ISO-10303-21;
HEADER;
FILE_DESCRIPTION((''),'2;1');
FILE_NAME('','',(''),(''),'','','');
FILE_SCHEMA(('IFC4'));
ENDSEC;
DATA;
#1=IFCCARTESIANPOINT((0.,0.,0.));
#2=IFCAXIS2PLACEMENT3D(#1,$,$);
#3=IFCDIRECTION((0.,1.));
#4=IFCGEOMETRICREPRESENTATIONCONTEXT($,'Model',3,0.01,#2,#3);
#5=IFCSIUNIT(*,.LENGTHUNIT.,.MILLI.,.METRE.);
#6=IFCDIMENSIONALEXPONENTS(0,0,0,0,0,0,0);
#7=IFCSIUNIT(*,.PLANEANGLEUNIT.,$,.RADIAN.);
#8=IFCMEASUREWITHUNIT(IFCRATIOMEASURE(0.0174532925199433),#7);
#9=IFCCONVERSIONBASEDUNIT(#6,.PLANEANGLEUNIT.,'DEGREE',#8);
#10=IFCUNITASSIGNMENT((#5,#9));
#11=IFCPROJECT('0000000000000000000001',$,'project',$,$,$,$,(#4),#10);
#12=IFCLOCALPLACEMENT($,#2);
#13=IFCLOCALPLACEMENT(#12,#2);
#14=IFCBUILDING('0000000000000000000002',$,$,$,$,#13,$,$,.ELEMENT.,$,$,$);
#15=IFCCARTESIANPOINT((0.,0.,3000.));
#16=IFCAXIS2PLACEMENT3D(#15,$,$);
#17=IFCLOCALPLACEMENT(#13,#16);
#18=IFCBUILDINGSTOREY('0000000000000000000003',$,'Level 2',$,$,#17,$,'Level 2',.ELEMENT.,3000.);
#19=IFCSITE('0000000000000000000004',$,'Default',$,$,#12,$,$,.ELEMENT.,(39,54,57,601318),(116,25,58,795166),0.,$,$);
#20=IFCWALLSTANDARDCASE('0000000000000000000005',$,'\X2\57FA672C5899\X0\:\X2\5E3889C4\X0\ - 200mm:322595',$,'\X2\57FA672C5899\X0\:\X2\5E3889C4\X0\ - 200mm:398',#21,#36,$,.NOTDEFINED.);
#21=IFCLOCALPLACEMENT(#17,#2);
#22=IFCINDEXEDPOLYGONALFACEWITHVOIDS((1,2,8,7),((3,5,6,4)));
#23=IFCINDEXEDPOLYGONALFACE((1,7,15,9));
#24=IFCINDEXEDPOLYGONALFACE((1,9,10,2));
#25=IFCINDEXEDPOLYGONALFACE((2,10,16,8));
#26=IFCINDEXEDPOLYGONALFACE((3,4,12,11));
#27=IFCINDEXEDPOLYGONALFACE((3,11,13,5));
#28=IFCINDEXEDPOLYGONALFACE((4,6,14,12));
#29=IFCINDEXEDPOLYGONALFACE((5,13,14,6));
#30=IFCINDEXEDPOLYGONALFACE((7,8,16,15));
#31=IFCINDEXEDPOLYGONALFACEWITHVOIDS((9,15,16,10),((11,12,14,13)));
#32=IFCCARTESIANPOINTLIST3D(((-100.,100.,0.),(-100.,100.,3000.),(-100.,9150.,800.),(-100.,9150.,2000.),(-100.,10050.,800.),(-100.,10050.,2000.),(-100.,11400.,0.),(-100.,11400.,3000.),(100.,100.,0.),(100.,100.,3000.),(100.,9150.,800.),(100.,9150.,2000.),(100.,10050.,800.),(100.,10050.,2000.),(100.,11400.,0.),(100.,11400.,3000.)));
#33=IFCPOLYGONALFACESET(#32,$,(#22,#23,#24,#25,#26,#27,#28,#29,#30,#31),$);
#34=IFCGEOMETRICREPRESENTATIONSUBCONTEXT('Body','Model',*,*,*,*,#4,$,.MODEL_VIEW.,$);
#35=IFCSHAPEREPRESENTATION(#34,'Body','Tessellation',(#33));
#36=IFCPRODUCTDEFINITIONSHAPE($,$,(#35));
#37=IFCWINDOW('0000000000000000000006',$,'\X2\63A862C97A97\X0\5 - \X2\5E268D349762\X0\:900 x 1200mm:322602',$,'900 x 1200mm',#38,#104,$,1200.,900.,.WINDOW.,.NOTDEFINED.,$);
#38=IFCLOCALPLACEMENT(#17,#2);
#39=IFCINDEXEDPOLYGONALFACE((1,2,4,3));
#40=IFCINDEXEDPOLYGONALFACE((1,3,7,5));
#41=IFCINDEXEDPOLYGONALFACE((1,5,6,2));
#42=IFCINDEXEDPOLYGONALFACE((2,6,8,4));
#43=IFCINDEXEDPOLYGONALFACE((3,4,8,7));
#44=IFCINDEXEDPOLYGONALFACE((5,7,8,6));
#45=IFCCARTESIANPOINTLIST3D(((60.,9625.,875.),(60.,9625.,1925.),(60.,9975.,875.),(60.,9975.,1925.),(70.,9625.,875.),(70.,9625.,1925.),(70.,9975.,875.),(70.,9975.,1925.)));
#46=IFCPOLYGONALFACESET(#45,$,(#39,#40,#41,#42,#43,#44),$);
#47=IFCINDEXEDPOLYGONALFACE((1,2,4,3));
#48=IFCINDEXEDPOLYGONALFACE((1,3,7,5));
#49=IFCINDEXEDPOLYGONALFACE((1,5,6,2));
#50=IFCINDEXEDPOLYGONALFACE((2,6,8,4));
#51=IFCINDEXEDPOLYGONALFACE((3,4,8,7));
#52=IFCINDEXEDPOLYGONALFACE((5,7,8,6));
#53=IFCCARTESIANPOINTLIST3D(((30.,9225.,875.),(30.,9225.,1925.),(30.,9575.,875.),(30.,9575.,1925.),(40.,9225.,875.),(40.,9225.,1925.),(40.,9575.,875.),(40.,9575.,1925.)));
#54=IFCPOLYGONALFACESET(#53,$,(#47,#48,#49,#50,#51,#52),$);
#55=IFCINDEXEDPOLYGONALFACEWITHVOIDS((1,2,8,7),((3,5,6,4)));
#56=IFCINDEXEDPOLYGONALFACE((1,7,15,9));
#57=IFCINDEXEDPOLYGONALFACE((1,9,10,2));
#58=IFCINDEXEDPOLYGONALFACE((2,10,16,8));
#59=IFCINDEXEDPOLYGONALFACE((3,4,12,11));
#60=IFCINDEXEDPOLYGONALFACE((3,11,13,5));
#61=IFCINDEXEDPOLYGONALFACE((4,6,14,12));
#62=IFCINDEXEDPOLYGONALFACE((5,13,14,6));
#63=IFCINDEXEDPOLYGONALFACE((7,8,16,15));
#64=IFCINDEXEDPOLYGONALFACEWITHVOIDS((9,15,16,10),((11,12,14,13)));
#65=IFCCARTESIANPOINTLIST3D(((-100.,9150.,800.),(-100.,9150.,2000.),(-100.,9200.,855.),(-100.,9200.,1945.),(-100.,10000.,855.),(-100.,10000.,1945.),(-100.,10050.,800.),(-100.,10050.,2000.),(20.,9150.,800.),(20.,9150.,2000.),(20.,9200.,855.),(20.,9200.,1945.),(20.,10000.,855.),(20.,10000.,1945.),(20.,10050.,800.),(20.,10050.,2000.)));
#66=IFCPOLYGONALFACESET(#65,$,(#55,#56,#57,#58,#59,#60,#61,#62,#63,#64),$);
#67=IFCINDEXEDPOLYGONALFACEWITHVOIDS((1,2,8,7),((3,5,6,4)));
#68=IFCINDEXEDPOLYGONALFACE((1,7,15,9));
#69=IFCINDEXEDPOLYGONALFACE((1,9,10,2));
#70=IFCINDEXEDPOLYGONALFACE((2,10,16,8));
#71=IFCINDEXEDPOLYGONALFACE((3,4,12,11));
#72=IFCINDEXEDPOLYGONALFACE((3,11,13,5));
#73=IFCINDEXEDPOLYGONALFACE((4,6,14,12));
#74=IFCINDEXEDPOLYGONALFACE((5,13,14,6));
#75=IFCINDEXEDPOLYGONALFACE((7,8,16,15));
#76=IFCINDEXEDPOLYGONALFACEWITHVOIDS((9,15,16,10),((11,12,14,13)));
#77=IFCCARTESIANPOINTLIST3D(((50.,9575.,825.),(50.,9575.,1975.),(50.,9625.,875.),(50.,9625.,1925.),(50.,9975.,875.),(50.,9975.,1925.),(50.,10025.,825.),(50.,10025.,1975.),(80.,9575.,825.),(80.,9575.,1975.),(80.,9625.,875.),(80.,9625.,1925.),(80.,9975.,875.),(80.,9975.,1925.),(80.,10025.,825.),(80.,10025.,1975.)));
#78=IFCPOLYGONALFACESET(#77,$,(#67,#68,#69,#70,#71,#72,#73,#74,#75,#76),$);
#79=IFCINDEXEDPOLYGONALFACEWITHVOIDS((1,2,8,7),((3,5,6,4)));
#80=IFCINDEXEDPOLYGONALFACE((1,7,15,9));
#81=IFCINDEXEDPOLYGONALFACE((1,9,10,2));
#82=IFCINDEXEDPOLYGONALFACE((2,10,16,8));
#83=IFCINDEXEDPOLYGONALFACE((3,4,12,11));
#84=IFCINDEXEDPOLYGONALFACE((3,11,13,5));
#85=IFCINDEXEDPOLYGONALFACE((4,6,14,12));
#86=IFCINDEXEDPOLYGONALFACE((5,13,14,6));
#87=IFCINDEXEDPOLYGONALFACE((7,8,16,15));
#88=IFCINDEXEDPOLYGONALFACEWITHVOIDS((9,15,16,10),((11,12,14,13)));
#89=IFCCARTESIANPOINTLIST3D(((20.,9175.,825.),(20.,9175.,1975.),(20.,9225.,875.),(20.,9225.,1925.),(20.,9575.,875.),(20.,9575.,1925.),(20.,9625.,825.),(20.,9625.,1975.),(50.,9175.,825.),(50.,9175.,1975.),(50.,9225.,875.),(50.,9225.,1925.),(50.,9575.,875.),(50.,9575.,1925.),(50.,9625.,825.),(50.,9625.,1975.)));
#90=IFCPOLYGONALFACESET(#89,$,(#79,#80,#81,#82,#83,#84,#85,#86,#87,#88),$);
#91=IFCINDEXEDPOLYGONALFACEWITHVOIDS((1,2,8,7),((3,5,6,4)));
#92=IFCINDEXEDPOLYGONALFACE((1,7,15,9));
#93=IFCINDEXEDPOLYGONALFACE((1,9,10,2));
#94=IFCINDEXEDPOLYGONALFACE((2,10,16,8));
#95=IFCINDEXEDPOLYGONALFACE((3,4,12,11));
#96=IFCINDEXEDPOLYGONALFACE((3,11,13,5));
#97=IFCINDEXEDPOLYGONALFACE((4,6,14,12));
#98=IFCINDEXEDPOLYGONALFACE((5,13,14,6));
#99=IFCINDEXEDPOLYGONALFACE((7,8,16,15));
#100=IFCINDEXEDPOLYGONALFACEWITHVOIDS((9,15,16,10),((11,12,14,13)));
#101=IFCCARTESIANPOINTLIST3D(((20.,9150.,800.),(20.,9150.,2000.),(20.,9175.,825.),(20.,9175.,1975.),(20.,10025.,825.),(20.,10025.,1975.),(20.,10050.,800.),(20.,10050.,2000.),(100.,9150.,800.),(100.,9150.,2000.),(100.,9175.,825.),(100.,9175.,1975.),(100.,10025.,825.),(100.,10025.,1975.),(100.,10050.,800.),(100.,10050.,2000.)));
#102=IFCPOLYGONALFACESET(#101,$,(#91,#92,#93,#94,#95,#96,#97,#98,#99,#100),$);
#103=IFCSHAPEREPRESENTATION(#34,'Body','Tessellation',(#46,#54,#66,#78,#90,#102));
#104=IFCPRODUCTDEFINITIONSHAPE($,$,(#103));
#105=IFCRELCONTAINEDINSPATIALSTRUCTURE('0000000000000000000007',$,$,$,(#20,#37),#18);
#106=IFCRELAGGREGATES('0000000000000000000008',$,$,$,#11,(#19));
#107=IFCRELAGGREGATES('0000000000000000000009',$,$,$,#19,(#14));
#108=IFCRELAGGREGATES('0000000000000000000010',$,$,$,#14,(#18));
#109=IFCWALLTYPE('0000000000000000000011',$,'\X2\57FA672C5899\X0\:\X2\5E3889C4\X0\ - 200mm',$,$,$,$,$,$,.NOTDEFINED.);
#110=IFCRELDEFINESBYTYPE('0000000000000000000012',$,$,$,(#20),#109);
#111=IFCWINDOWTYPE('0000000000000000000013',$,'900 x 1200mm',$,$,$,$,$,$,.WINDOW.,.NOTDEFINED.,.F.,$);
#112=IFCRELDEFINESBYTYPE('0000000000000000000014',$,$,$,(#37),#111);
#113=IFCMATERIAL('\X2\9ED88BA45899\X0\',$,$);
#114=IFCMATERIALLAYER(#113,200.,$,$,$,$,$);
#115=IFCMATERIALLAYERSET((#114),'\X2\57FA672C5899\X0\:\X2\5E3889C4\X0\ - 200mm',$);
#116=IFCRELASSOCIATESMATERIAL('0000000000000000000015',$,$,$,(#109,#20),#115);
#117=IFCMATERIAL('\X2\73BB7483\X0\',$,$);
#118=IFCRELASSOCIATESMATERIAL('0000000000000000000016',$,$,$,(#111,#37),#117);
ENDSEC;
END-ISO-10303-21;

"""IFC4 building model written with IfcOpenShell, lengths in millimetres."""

from ifc_helpers import new_model, entity, si_unit, converted_unit, direction, frame, frame_2d, origin, origin_2d_with_axis, place, context, subcontext, project, spatial, polyline, rectangle, outline, extrude, source, transform, mapped, material, layer, layer_set, layer_usage, type_object, type_shapes, element, fill, save


model = new_model("IFC4")

# Units and contexts
model_context_1 = context("Model", 3, precision=0.01, world=origin(), true_north=direction((0.0, 1.0)))
body_context_1 = subcontext(model_context_1, "Body", "Model", "MODEL_VIEW")
ifc_project = project(units=[si_unit("LENGTHUNIT", "METRE", prefix="MILLI"), converted_unit("PLANEANGLEUNIT", "DEGREE", entity("IfcRatioMeasure", 0.0174532925199433), si_unit("PLANEANGLEUNIT", "RADIAN"), dimensions=[0, 0, 0, 0, 0, 0, 0])], contexts=[model_context_1])

# Site, building, storey
site_placement = place(None, origin())
site = spatial("IfcSite", under=ifc_project, at=site_placement, Name="Default", CompositionType="ELEMENT", RefLatitude=(39, 54, 57, 601318), RefLongitude=(116, 25, 58, 795166), RefElevation=0.0)
building_placement = place(site_placement, origin())
building = spatial("IfcBuilding", under=site, at=building_placement, CompositionType="ELEMENT")
storey_placement = place(building_placement, frame((0.0, 0.0, 3000.0)))
storey = spatial("IfcBuildingStorey", under=building, at=storey_placement, Name="Level 2", LongName="Level 2", CompositionType="ELEMENT", Elevation=3000.0)

# Shared definitions
ifc_material_1 = material(Name="默认墙")
ifc_layer_1 = layer(ifc_material_1, 200.0)
ifc_layer_set_1 = layer_set([ifc_layer_1], Name="基本墙:常规 - 200mm")
wall_type = type_object("IfcWallType", Name="基本墙:常规 - 200mm", PredefinedType="NOTDEFINED", material=ifc_layer_set_1)

# Wall, opening, window
ifc_material_2 = material(Name="玻璃")
window_type = type_object("IfcWindowType", Name="900 x 1200mm", ParameterTakesPrecedence=False, PartitioningType="NOTDEFINED", PredefinedType="WINDOW", material=ifc_material_2)
shared_shape_1 = source(origin(), body_context_1, "Body", "SweptSolid", [
    extrude(rectangle(XDim=10.0, YDim=350.0, at=origin_2d_with_axis()), frame((250.0, 165.0, 75.0), z_axis=(0.0, 0.0, 1.0), x_axis=(0.0, -1.0, 0.0)), (0.0, 0.0, 1.0), 1050.0),
    extrude(rectangle(XDim=10.0, YDim=350.0, at=frame_2d((0.0, 0.0), x_axis=(1.0, 0.0))), frame((650.0, 135.0, 75.0), z_axis=(0.0, 0.0, 1.0), x_axis=(0.0, -1.0, 0.0)), (0.0, 0.0, 1.0), 1050.0),
    extrude(outline(polyline([(-450.0, -600.0), (450.0, -600.0), (450.0, 600.0), (-450.0, 600.0), (-450.0, -600.0)]), holes=[polyline([(400.0, -545.0), (-400.0, -545.0), (-400.0, 545.0), (400.0, 545.0), (400.0, -545.0)])]), frame((450.0, 0.0, 600.0), z_axis=(0.0, 1.0, 0.0), x_axis=(1.0, 0.0, 0.0)), (0.0, 0.0, 1.0), 120.0),
    extrude(outline(polyline([(-225.0, -575.0), (225.0, -575.0), (225.0, 575.0), (-225.0, 575.0), (-225.0, -575.0)]), holes=[polyline([(-175.0, -525.0), (-175.0, 525.0), (175.0, 525.0), (175.0, -525.0), (-175.0, -525.0)])]), frame((250.0, 150.0, 600.0), z_axis=(0.0, 1.0, 0.0), x_axis=(-1.0, 0.0, 0.0)), (0.0, 0.0, 1.0), 30.0),
    extrude(outline(polyline([(-225.0, -575.0), (225.0, -575.0), (225.0, 575.0), (-225.0, 575.0), (-225.0, -575.0)]), holes=[polyline([(-175.0, -525.0), (-175.0, 525.0), (175.0, 525.0), (175.0, -525.0), (-175.0, -525.0)])]), frame((650.0, 120.0, 600.0), z_axis=(0.0, 1.0, 0.0), x_axis=(1.0, 0.0, 0.0)), (0.0, 0.0, 1.0), 30.0),
    extrude(outline(polyline([(-450.0, -600.0), (450.0, -600.0), (450.0, 600.0), (-450.0, 600.0), (-450.0, -600.0)]), holes=[polyline([(-425.0, 575.0), (425.0, 575.0), (425.0, -575.0), (-425.0, -575.0), (-425.0, 575.0)])]), frame((450.0, 120.0, 600.0), z_axis=(0.0, 1.0, 0.0), x_axis=(1.0, 0.0, 0.0)), (0.0, 0.0, 1.0), 80.0),
])
type_shapes(window_type, [shared_shape_1])
ifc_layer_usage_1 = layer_usage(ifc_layer_set_1, "AXIS2", "NEGATIVE", 100.0)
wall_1_placement = place(storey_placement, frame((0.0, 100.0, 0.0), z_axis=(0.0, 0.0, 1.0), x_axis=(0.0, 1.0, 0.0)))
wall_1 = element("IfcWallStandardCase", 1, at=wall_1_placement, inside=storey, type_object=wall_type, material=ifc_layer_usage_1, Name="基本墙:常规 - 200mm:322595", ObjectType="基本墙:常规 - 200mm:398", PredefinedType="NOTDEFINED", context=body_context_1, shape_type="SweptSolid", body=[
    extrude(rectangle(XDim=11300.0, YDim=200.0, at=frame_2d((5650.0, 0.0), x_axis=(-1.0, 0.0))), origin(), (0.0, 0.0, 1.0), 3000.0),
])
opening_1_placement = place(wall_1_placement, frame((9950.0, 100.0, 800.0)))
opening_1 = element("IfcOpeningElement", 2, at=opening_1_placement, cuts=wall_1, ObjectType="Opening", PredefinedType="OPENING", context=body_context_1, shape_type="SweptSolid", body=[
    extrude(rectangle(XDim=1200.0, YDim=900.0, at=frame_2d((600.0, 450.0), x_axis=(-1.0, 0.0))), frame((0.0, 0.0, 0.0), z_axis=(0.0, -1.0, 0.0), x_axis=(0.0, 0.0, 1.0)), (0.0, 0.0, 1.0), 200.0),
])
window_1_placement = place(opening_1_placement, frame((0.0, 0.0, 0.0), z_axis=(0.0, 0.0, 1.0), x_axis=(-1.0, 0.0, 0.0)))
window_1 = element("IfcWindow", 3, at=window_1_placement, inside=storey, type_object=window_type, material=ifc_material_2, Name="推拉窗5 - 带贴面:900 x 1200mm:322602", ObjectType="900 x 1200mm", OverallHeight=1200.0, OverallWidth=900.0, PartitioningType="NOTDEFINED", PredefinedType="WINDOW", context=body_context_1, shape_type="MappedRepresentation", body=[
    mapped(shared_shape_1, transform((0.0, 0.0, 0.0), scale=1.0)),
])
fill(opening_1, window_1)

save(model, "model.ifc")
